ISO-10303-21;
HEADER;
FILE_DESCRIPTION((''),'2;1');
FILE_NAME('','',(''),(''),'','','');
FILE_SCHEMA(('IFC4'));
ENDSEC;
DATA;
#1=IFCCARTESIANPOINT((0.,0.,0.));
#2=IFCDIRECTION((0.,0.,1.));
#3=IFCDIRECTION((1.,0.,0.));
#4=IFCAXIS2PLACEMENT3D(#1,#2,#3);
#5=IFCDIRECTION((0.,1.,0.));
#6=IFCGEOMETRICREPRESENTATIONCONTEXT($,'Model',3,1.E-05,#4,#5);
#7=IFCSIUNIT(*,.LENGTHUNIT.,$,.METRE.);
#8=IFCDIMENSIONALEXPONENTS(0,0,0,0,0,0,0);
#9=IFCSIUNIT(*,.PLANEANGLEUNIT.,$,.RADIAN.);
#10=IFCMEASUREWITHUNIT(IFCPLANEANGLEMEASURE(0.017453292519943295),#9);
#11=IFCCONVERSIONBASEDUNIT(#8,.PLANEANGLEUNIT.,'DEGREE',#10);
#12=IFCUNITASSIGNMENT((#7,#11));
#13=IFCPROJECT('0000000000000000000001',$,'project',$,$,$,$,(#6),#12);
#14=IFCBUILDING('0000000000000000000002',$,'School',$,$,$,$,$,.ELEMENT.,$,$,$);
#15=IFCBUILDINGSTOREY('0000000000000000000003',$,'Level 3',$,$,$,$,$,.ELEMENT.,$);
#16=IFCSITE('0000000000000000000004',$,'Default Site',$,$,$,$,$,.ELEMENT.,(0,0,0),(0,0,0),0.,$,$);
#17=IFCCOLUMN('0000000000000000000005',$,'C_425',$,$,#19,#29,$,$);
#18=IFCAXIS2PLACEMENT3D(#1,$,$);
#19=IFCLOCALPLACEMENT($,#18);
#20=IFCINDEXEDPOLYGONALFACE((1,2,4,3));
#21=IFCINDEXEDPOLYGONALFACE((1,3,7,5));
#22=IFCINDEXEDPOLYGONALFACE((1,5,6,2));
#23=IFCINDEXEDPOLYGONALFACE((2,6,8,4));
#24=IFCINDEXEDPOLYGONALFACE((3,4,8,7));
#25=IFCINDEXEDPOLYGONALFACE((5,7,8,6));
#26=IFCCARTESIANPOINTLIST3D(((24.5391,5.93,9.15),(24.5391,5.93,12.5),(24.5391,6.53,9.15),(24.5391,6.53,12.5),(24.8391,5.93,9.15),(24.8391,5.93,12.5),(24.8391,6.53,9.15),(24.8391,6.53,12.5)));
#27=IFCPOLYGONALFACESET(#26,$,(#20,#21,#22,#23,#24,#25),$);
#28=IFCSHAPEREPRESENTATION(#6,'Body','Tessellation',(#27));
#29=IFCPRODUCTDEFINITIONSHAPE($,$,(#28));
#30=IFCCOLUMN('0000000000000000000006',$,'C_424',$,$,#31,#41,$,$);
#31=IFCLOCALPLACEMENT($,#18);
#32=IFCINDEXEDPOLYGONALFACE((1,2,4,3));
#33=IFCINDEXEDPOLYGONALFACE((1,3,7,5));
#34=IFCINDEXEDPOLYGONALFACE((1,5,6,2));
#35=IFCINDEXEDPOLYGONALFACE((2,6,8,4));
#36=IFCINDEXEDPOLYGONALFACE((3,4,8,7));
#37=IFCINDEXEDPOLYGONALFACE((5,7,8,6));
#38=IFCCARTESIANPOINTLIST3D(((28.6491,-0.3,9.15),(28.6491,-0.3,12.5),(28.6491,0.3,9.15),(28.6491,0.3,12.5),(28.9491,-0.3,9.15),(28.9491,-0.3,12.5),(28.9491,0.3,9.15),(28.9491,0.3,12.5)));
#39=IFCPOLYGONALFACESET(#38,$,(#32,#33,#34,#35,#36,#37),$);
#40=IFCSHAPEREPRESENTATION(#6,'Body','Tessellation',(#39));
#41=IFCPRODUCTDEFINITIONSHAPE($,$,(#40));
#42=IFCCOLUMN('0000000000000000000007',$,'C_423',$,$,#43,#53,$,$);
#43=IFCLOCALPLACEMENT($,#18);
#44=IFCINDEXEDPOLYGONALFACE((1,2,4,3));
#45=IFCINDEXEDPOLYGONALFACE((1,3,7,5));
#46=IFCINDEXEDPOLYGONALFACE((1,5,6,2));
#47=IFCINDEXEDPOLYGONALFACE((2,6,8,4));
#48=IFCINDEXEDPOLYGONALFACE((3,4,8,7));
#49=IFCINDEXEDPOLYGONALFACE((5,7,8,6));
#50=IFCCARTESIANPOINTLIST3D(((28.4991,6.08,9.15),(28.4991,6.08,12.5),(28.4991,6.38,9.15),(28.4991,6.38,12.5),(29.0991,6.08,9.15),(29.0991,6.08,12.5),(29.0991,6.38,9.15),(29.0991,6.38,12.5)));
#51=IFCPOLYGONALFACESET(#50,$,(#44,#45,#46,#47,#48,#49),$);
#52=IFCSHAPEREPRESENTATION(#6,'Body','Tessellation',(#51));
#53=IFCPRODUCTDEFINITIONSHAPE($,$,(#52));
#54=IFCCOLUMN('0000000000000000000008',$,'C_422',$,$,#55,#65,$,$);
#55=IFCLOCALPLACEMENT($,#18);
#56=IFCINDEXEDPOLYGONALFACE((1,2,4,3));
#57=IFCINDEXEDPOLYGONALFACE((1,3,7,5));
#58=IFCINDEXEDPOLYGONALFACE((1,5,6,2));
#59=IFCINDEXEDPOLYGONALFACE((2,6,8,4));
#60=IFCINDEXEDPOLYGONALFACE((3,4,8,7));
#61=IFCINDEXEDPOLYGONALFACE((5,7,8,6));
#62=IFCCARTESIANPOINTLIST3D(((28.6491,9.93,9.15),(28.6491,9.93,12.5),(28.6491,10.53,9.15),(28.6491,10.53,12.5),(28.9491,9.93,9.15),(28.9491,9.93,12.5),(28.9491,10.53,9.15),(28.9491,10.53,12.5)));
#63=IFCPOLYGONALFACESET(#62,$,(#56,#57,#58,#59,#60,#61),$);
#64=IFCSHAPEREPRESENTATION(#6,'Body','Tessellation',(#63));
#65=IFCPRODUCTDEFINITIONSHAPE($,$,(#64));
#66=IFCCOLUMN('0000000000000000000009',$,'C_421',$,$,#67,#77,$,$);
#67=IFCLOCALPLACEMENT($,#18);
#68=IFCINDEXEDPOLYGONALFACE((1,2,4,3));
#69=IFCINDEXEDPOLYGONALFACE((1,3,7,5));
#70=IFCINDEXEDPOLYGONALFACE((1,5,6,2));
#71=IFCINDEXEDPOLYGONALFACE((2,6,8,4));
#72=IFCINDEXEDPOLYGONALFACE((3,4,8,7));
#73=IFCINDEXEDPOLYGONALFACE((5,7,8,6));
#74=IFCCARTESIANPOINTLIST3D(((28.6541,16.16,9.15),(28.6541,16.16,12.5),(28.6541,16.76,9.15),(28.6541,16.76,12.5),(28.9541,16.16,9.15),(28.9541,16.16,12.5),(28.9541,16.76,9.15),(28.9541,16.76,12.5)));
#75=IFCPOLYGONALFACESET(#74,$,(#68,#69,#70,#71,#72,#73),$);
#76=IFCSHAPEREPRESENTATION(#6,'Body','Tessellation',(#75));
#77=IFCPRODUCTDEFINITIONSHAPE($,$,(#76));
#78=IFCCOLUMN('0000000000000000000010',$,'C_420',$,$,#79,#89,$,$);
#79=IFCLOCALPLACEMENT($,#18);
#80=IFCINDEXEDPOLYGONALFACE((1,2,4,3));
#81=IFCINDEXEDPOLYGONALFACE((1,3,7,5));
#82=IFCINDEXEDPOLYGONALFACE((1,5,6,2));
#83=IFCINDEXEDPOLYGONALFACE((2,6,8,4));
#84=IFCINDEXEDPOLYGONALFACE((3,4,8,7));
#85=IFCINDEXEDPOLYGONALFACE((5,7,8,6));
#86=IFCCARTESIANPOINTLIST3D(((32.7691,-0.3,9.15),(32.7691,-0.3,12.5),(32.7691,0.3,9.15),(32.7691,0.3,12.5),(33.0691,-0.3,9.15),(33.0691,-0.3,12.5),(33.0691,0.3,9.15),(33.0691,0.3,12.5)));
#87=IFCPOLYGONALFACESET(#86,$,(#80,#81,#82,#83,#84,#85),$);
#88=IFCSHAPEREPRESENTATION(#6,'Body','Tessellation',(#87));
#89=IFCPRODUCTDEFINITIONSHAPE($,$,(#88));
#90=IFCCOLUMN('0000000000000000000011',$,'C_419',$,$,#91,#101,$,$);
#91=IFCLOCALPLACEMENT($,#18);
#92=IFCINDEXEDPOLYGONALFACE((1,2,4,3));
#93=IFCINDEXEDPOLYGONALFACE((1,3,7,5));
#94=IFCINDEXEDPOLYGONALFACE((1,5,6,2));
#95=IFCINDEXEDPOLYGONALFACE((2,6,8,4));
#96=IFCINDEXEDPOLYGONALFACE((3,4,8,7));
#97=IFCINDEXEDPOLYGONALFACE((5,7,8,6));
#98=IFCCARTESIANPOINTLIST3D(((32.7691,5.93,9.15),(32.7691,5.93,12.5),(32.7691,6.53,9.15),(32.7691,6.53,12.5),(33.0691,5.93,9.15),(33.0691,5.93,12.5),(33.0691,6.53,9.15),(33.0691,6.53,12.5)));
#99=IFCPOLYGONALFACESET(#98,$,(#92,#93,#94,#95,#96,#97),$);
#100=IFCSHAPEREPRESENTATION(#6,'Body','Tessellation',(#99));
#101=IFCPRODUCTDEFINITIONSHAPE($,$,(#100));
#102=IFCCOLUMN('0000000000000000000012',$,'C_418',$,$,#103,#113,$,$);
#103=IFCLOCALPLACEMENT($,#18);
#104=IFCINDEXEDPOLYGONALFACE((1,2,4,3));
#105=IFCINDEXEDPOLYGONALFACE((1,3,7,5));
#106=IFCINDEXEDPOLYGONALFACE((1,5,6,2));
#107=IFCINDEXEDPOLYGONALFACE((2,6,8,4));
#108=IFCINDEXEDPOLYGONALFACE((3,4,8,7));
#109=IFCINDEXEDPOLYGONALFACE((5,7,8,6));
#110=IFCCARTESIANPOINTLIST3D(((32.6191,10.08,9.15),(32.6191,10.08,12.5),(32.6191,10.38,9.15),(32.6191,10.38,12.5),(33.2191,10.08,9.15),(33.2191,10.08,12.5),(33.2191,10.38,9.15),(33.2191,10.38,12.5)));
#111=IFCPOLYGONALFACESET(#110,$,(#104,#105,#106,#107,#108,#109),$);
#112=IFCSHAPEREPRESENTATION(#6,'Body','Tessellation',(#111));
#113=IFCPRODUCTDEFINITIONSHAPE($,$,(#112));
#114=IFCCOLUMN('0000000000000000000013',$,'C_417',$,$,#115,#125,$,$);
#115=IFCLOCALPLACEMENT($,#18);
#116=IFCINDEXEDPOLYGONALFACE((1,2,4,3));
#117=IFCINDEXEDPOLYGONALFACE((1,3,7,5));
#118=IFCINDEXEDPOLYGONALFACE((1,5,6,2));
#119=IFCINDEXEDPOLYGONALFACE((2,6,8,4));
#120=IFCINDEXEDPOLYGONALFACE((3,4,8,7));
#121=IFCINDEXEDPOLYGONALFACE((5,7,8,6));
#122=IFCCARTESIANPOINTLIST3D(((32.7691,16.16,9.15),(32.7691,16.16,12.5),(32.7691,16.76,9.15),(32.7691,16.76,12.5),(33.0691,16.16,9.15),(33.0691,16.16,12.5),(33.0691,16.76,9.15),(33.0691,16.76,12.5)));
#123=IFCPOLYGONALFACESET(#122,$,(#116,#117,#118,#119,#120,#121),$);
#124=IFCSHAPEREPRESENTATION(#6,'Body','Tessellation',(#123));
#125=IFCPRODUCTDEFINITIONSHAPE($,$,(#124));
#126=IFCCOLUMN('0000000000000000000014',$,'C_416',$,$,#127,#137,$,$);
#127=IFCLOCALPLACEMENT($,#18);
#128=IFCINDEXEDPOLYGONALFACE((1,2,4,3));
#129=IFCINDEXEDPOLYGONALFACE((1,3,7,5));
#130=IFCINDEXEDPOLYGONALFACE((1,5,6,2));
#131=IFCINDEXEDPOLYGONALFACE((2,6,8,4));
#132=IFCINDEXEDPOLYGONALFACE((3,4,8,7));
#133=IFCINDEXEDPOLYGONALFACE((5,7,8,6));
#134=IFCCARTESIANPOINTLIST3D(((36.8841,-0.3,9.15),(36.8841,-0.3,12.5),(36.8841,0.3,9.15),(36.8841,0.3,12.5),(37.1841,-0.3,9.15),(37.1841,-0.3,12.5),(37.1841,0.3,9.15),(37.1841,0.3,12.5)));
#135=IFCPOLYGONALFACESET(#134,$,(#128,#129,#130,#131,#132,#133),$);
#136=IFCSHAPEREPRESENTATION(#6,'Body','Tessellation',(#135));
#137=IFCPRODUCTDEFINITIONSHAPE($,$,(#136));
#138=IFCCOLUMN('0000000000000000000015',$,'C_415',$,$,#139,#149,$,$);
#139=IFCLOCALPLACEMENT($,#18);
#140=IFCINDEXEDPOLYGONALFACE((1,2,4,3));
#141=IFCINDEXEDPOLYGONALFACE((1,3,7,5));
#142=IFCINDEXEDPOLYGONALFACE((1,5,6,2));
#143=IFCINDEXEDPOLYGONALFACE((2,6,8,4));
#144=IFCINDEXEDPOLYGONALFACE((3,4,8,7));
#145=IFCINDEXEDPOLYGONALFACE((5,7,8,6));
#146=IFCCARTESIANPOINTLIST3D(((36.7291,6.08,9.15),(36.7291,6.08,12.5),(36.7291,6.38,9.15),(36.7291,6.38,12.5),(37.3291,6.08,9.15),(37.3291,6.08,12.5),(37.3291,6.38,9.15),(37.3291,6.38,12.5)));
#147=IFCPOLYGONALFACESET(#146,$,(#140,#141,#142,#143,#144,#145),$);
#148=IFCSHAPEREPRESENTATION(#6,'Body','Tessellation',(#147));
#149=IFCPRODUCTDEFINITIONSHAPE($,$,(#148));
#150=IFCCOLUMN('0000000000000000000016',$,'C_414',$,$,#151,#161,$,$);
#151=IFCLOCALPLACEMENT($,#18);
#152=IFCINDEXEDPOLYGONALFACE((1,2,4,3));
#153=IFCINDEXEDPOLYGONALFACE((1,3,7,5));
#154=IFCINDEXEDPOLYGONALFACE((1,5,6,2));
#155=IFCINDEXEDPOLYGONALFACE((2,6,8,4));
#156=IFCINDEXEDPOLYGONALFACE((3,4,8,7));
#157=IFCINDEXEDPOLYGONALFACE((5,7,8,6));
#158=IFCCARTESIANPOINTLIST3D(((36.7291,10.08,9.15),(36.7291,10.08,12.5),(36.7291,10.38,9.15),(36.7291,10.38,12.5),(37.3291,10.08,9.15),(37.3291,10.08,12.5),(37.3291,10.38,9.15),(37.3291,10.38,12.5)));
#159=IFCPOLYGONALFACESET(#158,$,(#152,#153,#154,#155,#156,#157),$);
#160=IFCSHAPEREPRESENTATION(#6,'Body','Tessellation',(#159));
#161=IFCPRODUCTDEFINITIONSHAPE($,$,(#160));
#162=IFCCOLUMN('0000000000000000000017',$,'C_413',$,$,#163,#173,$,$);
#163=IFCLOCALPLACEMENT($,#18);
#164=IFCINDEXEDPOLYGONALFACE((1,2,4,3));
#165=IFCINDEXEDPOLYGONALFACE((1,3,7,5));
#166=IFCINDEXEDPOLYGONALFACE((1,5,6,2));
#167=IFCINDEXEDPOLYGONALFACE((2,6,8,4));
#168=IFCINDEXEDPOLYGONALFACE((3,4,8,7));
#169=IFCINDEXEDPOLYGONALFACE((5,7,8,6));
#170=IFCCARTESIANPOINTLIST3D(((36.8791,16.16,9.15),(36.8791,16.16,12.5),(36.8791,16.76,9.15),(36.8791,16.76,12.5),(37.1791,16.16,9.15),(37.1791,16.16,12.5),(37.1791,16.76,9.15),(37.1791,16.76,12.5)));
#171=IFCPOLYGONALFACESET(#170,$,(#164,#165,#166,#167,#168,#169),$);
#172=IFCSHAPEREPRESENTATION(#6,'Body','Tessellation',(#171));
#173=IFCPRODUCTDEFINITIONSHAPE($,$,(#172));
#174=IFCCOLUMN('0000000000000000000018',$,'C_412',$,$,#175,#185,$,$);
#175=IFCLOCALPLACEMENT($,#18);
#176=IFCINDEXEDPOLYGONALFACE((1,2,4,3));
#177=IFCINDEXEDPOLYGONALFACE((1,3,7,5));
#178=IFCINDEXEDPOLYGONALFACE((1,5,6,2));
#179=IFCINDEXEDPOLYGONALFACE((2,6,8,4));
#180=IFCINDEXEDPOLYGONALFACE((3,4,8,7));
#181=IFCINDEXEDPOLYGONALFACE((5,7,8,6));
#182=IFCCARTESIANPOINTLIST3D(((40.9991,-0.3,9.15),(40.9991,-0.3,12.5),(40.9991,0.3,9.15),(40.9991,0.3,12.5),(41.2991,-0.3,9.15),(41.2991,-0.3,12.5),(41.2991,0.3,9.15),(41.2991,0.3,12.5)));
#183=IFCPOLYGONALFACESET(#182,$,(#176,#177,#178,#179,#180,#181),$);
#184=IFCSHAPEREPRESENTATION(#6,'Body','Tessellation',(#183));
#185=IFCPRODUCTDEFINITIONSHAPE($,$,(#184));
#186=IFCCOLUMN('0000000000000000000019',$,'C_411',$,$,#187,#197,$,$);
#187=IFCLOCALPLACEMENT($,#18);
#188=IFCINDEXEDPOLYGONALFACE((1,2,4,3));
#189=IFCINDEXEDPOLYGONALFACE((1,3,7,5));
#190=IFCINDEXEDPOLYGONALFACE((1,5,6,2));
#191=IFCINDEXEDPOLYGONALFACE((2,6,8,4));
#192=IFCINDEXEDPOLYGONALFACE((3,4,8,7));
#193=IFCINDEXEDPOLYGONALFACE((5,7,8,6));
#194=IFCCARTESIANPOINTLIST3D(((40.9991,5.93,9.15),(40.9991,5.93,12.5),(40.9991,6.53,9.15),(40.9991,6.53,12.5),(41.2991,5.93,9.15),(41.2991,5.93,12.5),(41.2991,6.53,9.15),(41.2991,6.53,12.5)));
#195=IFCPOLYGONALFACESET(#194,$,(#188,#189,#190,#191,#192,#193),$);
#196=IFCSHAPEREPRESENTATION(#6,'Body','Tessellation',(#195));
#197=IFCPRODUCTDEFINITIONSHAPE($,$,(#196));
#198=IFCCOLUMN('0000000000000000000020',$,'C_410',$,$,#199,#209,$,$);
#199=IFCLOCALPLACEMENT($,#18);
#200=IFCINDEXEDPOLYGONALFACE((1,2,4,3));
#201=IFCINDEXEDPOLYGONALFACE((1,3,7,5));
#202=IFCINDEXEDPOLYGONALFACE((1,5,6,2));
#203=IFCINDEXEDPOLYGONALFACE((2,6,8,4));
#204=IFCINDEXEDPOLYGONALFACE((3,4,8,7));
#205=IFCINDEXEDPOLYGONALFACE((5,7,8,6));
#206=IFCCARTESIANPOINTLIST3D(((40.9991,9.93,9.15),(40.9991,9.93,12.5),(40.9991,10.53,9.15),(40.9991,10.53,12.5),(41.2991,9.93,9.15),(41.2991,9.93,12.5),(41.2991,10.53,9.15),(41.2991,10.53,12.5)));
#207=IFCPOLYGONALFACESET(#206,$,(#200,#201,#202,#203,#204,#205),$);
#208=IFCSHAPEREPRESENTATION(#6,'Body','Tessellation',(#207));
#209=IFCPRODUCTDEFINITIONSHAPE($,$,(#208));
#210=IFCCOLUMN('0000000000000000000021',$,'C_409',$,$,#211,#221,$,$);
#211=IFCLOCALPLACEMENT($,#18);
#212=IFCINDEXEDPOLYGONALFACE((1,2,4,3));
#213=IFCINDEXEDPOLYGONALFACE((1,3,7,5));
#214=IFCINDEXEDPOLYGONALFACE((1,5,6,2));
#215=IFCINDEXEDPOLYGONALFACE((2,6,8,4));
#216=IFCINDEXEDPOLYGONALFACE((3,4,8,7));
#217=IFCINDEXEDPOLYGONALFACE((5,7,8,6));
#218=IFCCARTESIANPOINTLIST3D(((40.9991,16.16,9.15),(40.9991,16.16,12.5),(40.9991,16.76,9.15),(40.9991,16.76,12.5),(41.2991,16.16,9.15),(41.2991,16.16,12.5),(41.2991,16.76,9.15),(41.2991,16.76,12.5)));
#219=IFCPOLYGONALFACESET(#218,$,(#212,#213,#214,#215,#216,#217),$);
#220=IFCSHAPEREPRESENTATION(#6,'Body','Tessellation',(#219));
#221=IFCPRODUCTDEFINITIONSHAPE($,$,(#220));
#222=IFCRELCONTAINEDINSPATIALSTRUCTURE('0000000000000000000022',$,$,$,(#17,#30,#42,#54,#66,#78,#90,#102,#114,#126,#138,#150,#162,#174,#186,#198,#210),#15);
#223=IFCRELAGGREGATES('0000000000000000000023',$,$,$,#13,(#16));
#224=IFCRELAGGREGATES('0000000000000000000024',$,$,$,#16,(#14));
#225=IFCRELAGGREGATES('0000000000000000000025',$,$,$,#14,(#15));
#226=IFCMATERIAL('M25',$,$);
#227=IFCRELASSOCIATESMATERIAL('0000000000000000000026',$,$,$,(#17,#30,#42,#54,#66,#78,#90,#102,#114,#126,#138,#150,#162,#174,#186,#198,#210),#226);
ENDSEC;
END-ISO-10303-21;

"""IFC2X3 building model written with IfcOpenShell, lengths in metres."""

from ifc_helpers import new_model, entity, si_unit, converted_unit, direction, frame, frame_2d, origin_with_axes, place, context, project, spatial, rectangle, extrude, material, element, save


model = new_model("IFC2X3")

# Units and contexts
model_context = context("Model", 3, precision=1e-05, world=origin_with_axes(), true_north=direction((0.0, 1.0, 0.0)))
ifc_project = project(units=[si_unit("LENGTHUNIT", "METRE"), converted_unit("PLANEANGLEUNIT", "DEGREE", entity("IfcPlaneAngleMeasure", 0.017453292519943295), si_unit("PLANEANGLEUNIT", "RADIAN"), dimensions=[0, 0, 0, 0, 0, 0, 0])], contexts=[model_context])

# Site, building, storey
site = spatial("IfcSite", under=ifc_project, Name="Default Site", CompositionType="ELEMENT", RefLatitude=(0, 0, 0), RefLongitude=(0, 0, 0), RefElevation=0.0)
building = spatial("IfcBuilding", under=site, Name="School", CompositionType="ELEMENT")
storey = spatial("IfcBuildingStorey", under=building, Name="Level 3", CompositionType="ELEMENT")

# Columns
ifc_material = material(Name="M25")
placement = place(None, origin_with_axes())
element("IfcColumn", 1, at=placement, inside=storey, material=ifc_material, Name="C_425", context=model_context, shape_type="SweptSolid", body=[
    extrude(rectangle(XDim=0.3, YDim=0.6, at=frame_2d((0.0, 0.0), x_axis=(1.0, 0.0, 0.0))), frame((24.6891, 6.23, 9.15), z_axis=(0.0, 0.0, 1.0), x_axis=(1.0, 0.0, 0.0)), (0.0, 0.0, 1.0), 3.35),
])
element("IfcColumn", 2, at=placement, inside=storey, material=ifc_material, Name="C_424", context=model_context, shape_type="SweptSolid", body=[
    extrude(rectangle(XDim=0.3, YDim=0.6, at=frame_2d((0.0, 0.0), x_axis=(1.0, 0.0, 0.0))), frame((28.7991, 0.0, 9.15), z_axis=(0.0, 0.0, 1.0), x_axis=(1.0, 0.0, 0.0)), (0.0, 0.0, 1.0), 3.35),
])
element("IfcColumn", 3, at=placement, inside=storey, material=ifc_material, Name="C_423", context=model_context, shape_type="SweptSolid", body=[
    extrude(rectangle(XDim=0.6, YDim=0.3, at=frame_2d((0.0, 0.0), x_axis=(1.0, 0.0, 0.0))), frame((28.7991, 6.23, 9.15), z_axis=(0.0, 0.0, 1.0), x_axis=(1.0, 0.0, 0.0)), (0.0, 0.0, 1.0), 3.35),
])
element("IfcColumn", 4, at=placement, inside=storey, material=ifc_material, Name="C_422", context=model_context, shape_type="SweptSolid", body=[
    extrude(rectangle(XDim=0.3, YDim=0.6, at=frame_2d((0.0, 0.0), x_axis=(1.0, 0.0, 0.0))), frame((28.7991, 10.23, 9.15), z_axis=(0.0, 0.0, 1.0), x_axis=(1.0, 0.0, 0.0)), (0.0, 0.0, 1.0), 3.35),
])
element("IfcColumn", 5, at=placement, inside=storey, material=ifc_material, Name="C_421", context=model_context, shape_type="SweptSolid", body=[
    extrude(rectangle(XDim=0.3, YDim=0.6, at=frame_2d((0.0, 0.0), x_axis=(1.0, 0.0, 0.0))), frame((28.8041, 16.46, 9.15), z_axis=(0.0, 0.0, 1.0), x_axis=(1.0, 0.0, 0.0)), (0.0, 0.0, 1.0), 3.35),
])
element("IfcColumn", 6, at=placement, inside=storey, material=ifc_material, Name="C_420", context=model_context, shape_type="SweptSolid", body=[
    extrude(rectangle(XDim=0.3, YDim=0.6, at=frame_2d((0.0, 0.0), x_axis=(1.0, 0.0, 0.0))), frame((32.9191, 0.0, 9.15), z_axis=(0.0, 0.0, 1.0), x_axis=(1.0, 0.0, 0.0)), (0.0, 0.0, 1.0), 3.35),
])
element("IfcColumn", 7, at=placement, inside=storey, material=ifc_material, Name="C_419", context=model_context, shape_type="SweptSolid", body=[
    extrude(rectangle(XDim=0.3, YDim=0.6, at=frame_2d((0.0, 0.0), x_axis=(1.0, 0.0, 0.0))), frame((32.9191, 6.23, 9.15), z_axis=(0.0, 0.0, 1.0), x_axis=(1.0, 0.0, 0.0)), (0.0, 0.0, 1.0), 3.35),
])
element("IfcColumn", 8, at=placement, inside=storey, material=ifc_material, Name="C_418", context=model_context, shape_type="SweptSolid", body=[
    extrude(rectangle(XDim=0.6, YDim=0.3, at=frame_2d((0.0, 0.0), x_axis=(1.0, 0.0, 0.0))), frame((32.9191, 10.23, 9.15), z_axis=(0.0, 0.0, 1.0), x_axis=(1.0, 0.0, 0.0)), (0.0, 0.0, 1.0), 3.35),
])
element("IfcColumn", 9, at=placement, inside=storey, material=ifc_material, Name="C_417", context=model_context, shape_type="SweptSolid", body=[
    extrude(rectangle(XDim=0.3, YDim=0.6, at=frame_2d((0.0, 0.0), x_axis=(1.0, 0.0, 0.0))), frame((32.9191, 16.46, 9.15), z_axis=(0.0, 0.0, 1.0), x_axis=(1.0, 0.0, 0.0)), (0.0, 0.0, 1.0), 3.35),
])
element("IfcColumn", 10, at=placement, inside=storey, material=ifc_material, Name="C_416", context=model_context, shape_type="SweptSolid", body=[
    extrude(rectangle(XDim=0.3, YDim=0.6, at=frame_2d((0.0, 0.0), x_axis=(1.0, 0.0, 0.0))), frame((37.0341, 0.0, 9.15), z_axis=(0.0, 0.0, 1.0), x_axis=(1.0, 0.0, 0.0)), (0.0, 0.0, 1.0), 3.35),
])
element("IfcColumn", 11, at=placement, inside=storey, material=ifc_material, Name="C_415", context=model_context, shape_type="SweptSolid", body=[
    extrude(rectangle(XDim=0.6, YDim=0.3, at=frame_2d((0.0, 0.0), x_axis=(1.0, 0.0, 0.0))), frame((37.0291, 6.23, 9.15), z_axis=(0.0, 0.0, 1.0), x_axis=(1.0, 0.0, 0.0)), (0.0, 0.0, 1.0), 3.35),
])
element("IfcColumn", 12, at=placement, inside=storey, material=ifc_material, Name="C_414", context=model_context, shape_type="SweptSolid", body=[
    extrude(rectangle(XDim=0.6, YDim=0.3, at=frame_2d((0.0, 0.0), x_axis=(1.0, 0.0, 0.0))), frame((37.0291, 10.23, 9.15), z_axis=(0.0, 0.0, 1.0), x_axis=(1.0, 0.0, 0.0)), (0.0, 0.0, 1.0), 3.35),
])
element("IfcColumn", 13, at=placement, inside=storey, material=ifc_material, Name="C_413", context=model_context, shape_type="SweptSolid", body=[
    extrude(rectangle(XDim=0.3, YDim=0.6, at=frame_2d((0.0, 0.0), x_axis=(1.0, 0.0, 0.0))), frame((37.0291, 16.46, 9.15), z_axis=(0.0, 0.0, 1.0), x_axis=(1.0, 0.0, 0.0)), (0.0, 0.0, 1.0), 3.35),
])
element("IfcColumn", 14, at=placement, inside=storey, material=ifc_material, Name="C_412", context=model_context, shape_type="SweptSolid", body=[
    extrude(rectangle(XDim=0.3, YDim=0.6, at=frame_2d((0.0, 0.0), x_axis=(1.0, 0.0, 0.0))), frame((41.1491, 0.0, 9.15), z_axis=(0.0, 0.0, 1.0), x_axis=(1.0, 0.0, 0.0)), (0.0, 0.0, 1.0), 3.35),
])
element("IfcColumn", 15, at=placement, inside=storey, material=ifc_material, Name="C_411", context=model_context, shape_type="SweptSolid", body=[
    extrude(rectangle(XDim=0.3, YDim=0.6, at=frame_2d((0.0, 0.0), x_axis=(1.0, 0.0, 0.0))), frame((41.1491, 6.23, 9.15), z_axis=(0.0, 0.0, 1.0), x_axis=(1.0, 0.0, 0.0)), (0.0, 0.0, 1.0), 3.35),
])
element("IfcColumn", 16, at=placement, inside=storey, material=ifc_material, Name="C_410", context=model_context, shape_type="SweptSolid", body=[
    extrude(rectangle(XDim=0.3, YDim=0.6, at=frame_2d((0.0, 0.0), x_axis=(1.0, 0.0, 0.0))), frame((41.1491, 10.23, 9.15), z_axis=(0.0, 0.0, 1.0), x_axis=(1.0, 0.0, 0.0)), (0.0, 0.0, 1.0), 3.35),
])
element("IfcColumn", 17, at=placement, inside=storey, material=ifc_material, Name="C_409", context=model_context, shape_type="SweptSolid", body=[
    extrude(rectangle(XDim=0.3, YDim=0.6, at=frame_2d((0.0, 0.0), x_axis=(1.0, 0.0, 0.0))), frame((41.1491, 16.46, 9.15), z_axis=(0.0, 0.0, 1.0), x_axis=(1.0, 0.0, 0.0)), (0.0, 0.0, 1.0), 3.35),
])

save(model, "model.ifc")
